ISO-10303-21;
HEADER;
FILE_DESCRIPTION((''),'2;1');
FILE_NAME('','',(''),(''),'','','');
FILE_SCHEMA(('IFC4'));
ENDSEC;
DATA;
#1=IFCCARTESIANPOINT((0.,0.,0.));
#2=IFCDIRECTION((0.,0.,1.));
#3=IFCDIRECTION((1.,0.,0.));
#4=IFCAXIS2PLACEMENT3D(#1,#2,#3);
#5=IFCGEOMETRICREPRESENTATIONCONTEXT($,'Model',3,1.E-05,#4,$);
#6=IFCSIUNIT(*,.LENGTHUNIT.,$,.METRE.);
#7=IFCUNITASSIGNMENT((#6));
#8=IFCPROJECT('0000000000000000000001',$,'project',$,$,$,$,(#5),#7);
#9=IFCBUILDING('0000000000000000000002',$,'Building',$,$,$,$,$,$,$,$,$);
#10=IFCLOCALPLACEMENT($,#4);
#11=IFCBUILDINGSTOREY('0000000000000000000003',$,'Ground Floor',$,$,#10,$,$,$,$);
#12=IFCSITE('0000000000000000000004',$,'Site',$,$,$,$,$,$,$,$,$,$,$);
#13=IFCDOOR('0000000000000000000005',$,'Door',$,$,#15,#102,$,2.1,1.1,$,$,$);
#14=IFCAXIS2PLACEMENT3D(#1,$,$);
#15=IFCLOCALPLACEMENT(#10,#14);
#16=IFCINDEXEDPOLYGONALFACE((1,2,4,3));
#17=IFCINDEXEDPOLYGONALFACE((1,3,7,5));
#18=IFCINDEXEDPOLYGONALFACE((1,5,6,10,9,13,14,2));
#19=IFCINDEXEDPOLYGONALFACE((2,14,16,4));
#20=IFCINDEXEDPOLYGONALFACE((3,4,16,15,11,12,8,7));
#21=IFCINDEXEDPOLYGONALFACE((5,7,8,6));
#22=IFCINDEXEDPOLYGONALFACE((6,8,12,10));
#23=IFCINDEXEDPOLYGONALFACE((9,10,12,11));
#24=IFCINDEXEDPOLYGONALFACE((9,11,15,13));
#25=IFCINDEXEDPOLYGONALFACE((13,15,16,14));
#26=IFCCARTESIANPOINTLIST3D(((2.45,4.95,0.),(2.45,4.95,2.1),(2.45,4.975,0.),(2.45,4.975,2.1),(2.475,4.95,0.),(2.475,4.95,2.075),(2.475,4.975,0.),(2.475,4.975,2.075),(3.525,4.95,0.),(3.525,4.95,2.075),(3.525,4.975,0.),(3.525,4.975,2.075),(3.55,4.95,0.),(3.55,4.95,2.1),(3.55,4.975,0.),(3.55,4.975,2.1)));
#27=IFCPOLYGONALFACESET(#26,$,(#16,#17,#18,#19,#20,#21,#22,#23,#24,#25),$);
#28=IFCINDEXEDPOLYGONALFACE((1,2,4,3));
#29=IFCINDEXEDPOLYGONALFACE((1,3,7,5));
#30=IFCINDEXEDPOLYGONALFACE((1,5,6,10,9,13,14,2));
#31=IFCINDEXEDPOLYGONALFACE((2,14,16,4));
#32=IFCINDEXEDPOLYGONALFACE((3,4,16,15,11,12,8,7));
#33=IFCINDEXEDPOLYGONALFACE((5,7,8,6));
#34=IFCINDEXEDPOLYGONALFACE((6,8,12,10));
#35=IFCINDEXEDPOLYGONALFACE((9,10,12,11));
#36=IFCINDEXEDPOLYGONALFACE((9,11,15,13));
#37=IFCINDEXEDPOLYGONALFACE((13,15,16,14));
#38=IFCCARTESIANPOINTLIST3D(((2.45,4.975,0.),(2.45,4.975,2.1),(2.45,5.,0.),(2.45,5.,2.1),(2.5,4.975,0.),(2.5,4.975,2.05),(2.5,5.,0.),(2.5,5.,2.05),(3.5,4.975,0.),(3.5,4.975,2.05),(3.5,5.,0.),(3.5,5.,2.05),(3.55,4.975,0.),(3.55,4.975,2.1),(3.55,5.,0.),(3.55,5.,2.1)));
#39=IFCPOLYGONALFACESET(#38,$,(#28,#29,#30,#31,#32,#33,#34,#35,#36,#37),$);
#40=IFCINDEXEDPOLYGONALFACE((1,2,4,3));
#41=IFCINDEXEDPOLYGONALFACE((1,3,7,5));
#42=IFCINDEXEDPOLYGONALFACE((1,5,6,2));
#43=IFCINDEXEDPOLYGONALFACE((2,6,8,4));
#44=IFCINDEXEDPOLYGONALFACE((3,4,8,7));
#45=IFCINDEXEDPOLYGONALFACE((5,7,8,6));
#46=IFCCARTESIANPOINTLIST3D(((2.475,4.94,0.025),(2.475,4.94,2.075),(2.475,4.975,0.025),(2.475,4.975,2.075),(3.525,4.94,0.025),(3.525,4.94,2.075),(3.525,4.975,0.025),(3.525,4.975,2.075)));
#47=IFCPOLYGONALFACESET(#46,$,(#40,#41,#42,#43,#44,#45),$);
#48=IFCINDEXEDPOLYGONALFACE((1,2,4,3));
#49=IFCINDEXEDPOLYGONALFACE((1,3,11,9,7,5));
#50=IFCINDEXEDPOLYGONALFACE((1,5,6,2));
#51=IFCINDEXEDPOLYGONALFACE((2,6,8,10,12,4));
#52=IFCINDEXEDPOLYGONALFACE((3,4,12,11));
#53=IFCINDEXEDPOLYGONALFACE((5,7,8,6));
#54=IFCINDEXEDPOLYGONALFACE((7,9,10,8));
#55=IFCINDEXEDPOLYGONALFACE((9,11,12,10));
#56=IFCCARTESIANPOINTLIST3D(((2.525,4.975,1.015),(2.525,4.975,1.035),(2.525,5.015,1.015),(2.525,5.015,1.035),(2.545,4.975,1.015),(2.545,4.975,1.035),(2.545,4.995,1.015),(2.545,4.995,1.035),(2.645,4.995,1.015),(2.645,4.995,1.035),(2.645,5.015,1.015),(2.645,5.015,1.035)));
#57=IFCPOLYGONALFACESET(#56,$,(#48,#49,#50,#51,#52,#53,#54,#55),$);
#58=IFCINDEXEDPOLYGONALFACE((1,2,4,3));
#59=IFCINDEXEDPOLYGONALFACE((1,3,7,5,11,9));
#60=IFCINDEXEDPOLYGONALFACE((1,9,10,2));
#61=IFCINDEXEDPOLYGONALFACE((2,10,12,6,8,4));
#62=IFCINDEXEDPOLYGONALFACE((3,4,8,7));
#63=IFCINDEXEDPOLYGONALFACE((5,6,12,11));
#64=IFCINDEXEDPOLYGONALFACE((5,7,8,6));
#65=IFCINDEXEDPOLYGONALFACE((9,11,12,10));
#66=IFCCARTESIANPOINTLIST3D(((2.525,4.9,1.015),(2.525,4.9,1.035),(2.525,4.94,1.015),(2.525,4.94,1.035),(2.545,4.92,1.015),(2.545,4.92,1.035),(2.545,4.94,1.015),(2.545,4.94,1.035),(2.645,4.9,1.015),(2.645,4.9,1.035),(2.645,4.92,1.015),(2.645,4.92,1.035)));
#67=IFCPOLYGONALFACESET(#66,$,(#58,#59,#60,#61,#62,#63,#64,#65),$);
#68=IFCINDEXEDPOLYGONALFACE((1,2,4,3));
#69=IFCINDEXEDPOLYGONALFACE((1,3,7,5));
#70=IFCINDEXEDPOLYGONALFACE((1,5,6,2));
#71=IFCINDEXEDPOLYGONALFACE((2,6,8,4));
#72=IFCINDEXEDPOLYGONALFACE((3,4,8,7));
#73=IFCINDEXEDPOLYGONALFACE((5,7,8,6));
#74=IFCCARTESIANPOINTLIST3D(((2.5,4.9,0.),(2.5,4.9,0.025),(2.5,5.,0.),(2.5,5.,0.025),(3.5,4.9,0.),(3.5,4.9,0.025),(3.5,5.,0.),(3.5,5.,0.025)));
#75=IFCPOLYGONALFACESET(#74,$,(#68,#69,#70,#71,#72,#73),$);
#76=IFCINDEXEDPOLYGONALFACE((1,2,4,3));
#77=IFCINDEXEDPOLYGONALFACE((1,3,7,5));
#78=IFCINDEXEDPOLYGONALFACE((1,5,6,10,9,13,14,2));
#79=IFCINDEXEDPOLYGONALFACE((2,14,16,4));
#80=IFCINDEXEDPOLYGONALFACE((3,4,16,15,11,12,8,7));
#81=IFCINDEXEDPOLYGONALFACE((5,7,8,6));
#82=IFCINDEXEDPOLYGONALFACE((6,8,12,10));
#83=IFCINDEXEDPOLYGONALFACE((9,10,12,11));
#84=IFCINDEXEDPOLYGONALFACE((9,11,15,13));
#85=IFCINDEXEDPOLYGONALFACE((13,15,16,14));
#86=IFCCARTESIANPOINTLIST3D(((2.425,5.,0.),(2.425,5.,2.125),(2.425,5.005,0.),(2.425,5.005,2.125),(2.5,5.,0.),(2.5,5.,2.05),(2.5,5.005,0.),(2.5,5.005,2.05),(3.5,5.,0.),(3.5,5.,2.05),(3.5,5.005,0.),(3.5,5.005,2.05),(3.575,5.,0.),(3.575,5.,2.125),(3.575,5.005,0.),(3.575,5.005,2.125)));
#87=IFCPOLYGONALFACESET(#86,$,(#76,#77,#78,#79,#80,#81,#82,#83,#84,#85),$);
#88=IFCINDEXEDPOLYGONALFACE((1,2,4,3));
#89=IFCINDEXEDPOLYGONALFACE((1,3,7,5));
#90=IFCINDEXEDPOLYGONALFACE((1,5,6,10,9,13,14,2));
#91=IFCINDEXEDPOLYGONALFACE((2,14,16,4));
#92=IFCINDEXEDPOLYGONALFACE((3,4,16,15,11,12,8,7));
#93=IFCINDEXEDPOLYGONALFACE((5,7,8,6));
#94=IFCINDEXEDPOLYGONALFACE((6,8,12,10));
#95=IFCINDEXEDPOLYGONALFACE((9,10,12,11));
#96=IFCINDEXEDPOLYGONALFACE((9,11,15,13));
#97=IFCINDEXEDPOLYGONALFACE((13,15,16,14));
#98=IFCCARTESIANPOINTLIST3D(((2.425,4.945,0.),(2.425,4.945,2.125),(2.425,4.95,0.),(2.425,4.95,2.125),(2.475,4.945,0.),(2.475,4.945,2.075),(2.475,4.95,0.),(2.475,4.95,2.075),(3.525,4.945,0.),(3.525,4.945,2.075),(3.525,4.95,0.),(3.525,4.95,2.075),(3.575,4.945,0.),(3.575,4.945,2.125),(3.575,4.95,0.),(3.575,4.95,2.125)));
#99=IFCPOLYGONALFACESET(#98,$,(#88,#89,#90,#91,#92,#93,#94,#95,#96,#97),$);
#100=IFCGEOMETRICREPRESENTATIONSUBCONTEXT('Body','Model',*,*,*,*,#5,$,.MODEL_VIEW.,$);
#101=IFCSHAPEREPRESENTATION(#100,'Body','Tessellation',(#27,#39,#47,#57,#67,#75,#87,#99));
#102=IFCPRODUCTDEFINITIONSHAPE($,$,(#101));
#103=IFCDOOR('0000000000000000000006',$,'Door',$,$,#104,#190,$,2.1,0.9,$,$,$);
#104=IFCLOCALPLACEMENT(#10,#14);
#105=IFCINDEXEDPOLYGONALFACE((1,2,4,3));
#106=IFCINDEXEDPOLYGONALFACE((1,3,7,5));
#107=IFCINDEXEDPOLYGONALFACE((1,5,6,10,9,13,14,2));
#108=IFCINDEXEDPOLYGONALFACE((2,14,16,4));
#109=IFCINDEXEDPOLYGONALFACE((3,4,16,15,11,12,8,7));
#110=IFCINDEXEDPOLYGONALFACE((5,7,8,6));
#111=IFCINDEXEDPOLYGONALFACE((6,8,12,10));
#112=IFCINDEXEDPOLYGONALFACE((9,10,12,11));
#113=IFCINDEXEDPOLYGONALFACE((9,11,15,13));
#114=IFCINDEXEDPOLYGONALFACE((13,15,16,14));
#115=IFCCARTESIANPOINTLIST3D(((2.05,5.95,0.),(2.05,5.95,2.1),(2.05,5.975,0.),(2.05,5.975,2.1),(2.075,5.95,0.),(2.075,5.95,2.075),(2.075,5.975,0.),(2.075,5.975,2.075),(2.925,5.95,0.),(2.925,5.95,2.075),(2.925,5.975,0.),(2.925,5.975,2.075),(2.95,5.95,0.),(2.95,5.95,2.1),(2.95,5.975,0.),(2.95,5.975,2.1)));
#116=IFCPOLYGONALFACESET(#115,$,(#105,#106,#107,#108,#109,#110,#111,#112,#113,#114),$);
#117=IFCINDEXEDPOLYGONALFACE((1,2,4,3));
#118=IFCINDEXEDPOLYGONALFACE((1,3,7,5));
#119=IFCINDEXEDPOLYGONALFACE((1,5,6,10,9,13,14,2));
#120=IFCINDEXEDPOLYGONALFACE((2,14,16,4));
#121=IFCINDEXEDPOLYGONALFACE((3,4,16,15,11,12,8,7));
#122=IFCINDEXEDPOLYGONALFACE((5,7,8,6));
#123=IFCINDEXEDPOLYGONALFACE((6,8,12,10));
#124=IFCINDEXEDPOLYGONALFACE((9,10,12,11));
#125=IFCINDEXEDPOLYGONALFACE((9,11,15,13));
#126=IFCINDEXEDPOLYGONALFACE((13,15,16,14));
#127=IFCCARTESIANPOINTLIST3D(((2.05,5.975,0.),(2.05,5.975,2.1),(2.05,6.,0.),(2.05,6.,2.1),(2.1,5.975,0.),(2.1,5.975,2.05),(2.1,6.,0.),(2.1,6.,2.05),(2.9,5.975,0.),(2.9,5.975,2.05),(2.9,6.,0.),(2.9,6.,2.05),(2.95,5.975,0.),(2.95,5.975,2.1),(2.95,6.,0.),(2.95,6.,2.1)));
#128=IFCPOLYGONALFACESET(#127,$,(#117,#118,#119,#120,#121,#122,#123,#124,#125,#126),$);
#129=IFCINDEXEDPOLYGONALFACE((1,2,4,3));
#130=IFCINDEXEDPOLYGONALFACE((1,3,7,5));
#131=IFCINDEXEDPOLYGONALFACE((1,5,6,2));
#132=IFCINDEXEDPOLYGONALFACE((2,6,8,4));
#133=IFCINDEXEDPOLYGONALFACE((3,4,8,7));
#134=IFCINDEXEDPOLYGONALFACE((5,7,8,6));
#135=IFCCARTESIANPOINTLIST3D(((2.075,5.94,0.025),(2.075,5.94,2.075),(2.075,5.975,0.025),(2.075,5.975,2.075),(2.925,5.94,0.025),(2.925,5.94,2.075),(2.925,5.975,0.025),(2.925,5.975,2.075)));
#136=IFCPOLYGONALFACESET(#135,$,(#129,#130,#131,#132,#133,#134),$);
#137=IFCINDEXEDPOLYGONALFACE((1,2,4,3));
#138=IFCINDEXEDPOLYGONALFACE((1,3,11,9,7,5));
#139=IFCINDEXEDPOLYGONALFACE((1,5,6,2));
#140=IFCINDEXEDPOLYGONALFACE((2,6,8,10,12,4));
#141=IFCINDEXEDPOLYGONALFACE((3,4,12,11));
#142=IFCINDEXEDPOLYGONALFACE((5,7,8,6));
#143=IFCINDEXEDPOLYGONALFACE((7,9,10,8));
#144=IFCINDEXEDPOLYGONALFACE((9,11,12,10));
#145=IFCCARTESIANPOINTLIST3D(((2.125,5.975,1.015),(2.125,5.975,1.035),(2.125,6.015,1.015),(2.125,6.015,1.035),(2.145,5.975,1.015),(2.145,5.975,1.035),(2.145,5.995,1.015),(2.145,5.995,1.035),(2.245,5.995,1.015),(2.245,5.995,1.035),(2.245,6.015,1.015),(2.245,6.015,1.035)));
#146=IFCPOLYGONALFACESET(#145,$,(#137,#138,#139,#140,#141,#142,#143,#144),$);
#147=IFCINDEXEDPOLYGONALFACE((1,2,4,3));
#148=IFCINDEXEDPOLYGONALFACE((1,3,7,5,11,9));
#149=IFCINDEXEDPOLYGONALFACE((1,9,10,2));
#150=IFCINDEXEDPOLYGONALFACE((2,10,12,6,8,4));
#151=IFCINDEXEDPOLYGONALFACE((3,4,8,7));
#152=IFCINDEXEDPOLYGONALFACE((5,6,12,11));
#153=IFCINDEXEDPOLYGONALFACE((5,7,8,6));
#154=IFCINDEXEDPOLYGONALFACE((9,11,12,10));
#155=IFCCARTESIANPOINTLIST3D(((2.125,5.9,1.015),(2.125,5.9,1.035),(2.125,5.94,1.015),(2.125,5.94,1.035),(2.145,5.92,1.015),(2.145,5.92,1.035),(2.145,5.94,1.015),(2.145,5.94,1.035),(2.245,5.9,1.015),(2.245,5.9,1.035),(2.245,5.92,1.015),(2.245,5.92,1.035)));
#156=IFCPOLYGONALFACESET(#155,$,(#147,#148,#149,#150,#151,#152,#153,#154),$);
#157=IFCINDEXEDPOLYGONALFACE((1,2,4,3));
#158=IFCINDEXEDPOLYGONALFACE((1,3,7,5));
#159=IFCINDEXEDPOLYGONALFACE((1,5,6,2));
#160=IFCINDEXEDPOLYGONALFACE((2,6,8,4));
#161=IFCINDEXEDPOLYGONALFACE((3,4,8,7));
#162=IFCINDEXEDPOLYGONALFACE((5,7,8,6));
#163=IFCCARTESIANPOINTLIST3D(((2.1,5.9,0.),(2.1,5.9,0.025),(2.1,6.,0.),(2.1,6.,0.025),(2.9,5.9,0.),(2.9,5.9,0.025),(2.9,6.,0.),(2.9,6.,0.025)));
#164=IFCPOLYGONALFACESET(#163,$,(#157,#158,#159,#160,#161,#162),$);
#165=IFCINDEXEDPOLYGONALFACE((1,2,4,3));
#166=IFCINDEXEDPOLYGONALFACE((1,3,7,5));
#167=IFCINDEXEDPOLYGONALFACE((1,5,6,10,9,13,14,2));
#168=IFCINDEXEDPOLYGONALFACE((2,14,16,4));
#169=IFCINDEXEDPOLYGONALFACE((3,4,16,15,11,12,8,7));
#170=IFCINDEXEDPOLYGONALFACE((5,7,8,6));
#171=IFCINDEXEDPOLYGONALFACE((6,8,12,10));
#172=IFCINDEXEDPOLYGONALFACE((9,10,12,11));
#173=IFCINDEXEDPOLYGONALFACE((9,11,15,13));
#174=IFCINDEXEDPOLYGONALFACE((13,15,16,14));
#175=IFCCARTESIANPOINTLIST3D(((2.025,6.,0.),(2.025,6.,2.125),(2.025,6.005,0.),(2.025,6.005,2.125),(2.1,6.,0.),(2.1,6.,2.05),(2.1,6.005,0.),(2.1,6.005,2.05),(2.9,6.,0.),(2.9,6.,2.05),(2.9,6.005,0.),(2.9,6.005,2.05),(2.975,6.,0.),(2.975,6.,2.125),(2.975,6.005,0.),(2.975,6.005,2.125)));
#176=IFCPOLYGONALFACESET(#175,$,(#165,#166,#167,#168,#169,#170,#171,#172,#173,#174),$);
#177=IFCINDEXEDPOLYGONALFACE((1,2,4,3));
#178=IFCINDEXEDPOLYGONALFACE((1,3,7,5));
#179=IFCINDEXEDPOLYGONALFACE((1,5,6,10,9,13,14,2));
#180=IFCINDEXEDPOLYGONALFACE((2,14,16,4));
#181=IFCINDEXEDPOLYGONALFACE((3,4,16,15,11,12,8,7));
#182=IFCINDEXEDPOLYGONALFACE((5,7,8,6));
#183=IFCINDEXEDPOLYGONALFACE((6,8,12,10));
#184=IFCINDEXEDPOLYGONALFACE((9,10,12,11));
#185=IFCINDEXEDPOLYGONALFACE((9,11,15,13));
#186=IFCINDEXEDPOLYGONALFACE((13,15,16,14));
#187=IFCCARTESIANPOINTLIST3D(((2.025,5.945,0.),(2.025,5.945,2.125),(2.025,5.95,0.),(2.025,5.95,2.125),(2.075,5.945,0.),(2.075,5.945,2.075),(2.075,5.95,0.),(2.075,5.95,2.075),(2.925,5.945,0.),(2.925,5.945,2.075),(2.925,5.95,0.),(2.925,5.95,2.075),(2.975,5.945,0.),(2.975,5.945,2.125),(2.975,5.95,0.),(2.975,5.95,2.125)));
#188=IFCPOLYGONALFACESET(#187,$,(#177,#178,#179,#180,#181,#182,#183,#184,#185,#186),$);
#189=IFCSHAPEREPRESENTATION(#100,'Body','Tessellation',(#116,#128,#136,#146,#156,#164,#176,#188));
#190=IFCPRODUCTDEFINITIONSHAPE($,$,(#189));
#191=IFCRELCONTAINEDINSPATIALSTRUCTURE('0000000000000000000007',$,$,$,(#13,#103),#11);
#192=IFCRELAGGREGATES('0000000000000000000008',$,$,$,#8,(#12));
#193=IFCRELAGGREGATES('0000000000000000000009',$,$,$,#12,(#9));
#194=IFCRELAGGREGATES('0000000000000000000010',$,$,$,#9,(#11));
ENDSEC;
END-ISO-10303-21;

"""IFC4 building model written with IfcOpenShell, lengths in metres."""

from ifc_helpers import new_model, si_unit, frame, origin_with_axes, place, context, subcontext, project, spatial, line, indexed_curve, outline, extrude, element, save


model = new_model("IFC4")

# Units and contexts
model_context = context("Model", 3, precision=1e-05, world=origin_with_axes())
body_context = subcontext(model_context, "Body", "Model", "MODEL_VIEW")
ifc_project = project(units=[si_unit("LENGTHUNIT", "METRE")], contexts=[model_context])

# Site, building, storey
site = spatial("IfcSite", under=ifc_project, Name="Site")
building = spatial("IfcBuilding", under=site, Name="Building")
storey_placement = place(None, origin_with_axes())
storey = spatial("IfcBuildingStorey", under=building, at=storey_placement, Name="Ground Floor")

# Doors
door_1_placement = place(storey_placement, frame((3.55, 5.0, 0.0), z_axis=(0.0, 0.0, 1.0), x_axis=(-1.0, 0.0, 0.0)))
element("IfcDoor", 1, at=door_1_placement, inside=storey, Name="Door", OverallHeight=2.1, OverallWidth=1.1, context=body_context, shape_type="SweptSolid", body=[
    extrude(outline(indexed_curve([(0.0, 0.0), (0.0, 2.1), (1.1, 2.1), (1.1, 0.0), (1.075, 0.0), (1.075, 2.075), (0.025, 2.075), (0.025, 0.0)], segments=[line(1, 2, 3, 4, 5, 6, 7, 8, 1)])), frame((0.0, 0.025, 0.0), z_axis=(0.0, -1.0, 0.0), x_axis=(1.0, 0.0, 0.0)), (0.0, 0.0, -1.0), 0.025),
    extrude(outline(indexed_curve([(0.0, 0.0), (0.0, 2.1), (1.1, 2.1), (1.1, 0.0), (1.05, 0.0), (1.05, 2.05), (0.05, 2.05), (0.05, 0.0)], segments=[line(1, 2, 3, 4, 5, 6, 7, 8, 1)])), frame((0.0, 0.0, 0.0), z_axis=(0.0, -1.0, 0.0), x_axis=(1.0, 0.0, 0.0)), (0.0, 0.0, -1.0), 0.025),
    extrude(outline(indexed_curve([(0.0, 0.0), (1.05, 0.0), (1.05, 0.035), (0.0, 0.035)], segments=[line(1, 2, 3, 4, 1)])), frame((0.025, 0.025, 0.025), z_axis=(0.0, 0.0, 1.0), x_axis=(1.0, 0.0, 0.0)), (0.0, 0.0, 1.0), 2.05),
    extrude(outline(indexed_curve([(0.0, 0.0), (0.0, -0.04), (-0.12, -0.04), (-0.12, -0.02), (-0.02, -0.02), (-0.02, 0.0)], segments=[line(1, 2, 3, 4, 5, 6, 1)])), frame((1.025, 0.025, 1.015), z_axis=(0.0, 0.0, 1.0), x_axis=(1.0, 0.0, 0.0)), (0.0, 0.0, 1.0), 0.02),
    extrude(outline(indexed_curve([(0.0, 0.0), (0.0, 0.04), (-0.12, 0.04), (-0.12, 0.02), (-0.02, 0.02), (-0.02, 0.0)], segments=[line(1, 2, 3, 4, 5, 6, 1)])), frame((1.025, 0.06, 1.015), z_axis=(0.0, 0.0, 1.0), x_axis=(1.0, 0.0, 0.0)), (0.0, 0.0, 1.0), 0.02),
    extrude(outline(indexed_curve([(0.0, 0.0), (1.0, 0.0), (1.0, 0.1), (0.0, 0.1)], segments=[line(1, 2, 3, 4, 1)])), frame((0.05, 0.0, 0.0), z_axis=(0.0, 0.0, 1.0), x_axis=(1.0, 0.0, 0.0)), (0.0, 0.0, 1.0), 0.025),
    extrude(outline(indexed_curve([(0.0, 0.0), (0.0, 2.125), (1.15, 2.125), (1.15, 0.0), (1.075, 0.0), (1.075, 2.05), (0.075, 2.05), (0.075, 0.0)], segments=[line(1, 2, 3, 4, 5, 6, 7, 8, 1)])), frame((-0.025, -0.005, 0.0), z_axis=(0.0, -1.0, 0.0), x_axis=(1.0, 0.0, 0.0)), (0.0, 0.0, -1.0), 0.005),
    extrude(outline(indexed_curve([(0.0, 0.0), (0.0, 2.125), (1.15, 2.125), (1.15, 0.0), (1.1, 0.0), (1.1, 2.075), (0.05, 2.075), (0.05, 0.0)], segments=[line(1, 2, 3, 4, 5, 6, 7, 8, 1)])), frame((-0.025, 0.05, 0.0), z_axis=(0.0, -1.0, 0.0), x_axis=(1.0, 0.0, 0.0)), (0.0, 0.0, -1.0), 0.005),
])
door_2_placement = place(storey_placement, frame((2.95, 6.0, 0.0), z_axis=(0.0, 0.0, 1.0), x_axis=(-1.0, 0.0, 0.0)))
element("IfcDoor", 2, at=door_2_placement, inside=storey, Name="Door", OverallHeight=2.1, OverallWidth=0.9, context=body_context, shape_type="SweptSolid", body=[
    extrude(outline(indexed_curve([(0.0, 0.0), (0.0, 2.1), (0.9, 2.1), (0.9, 0.0), (0.875, 0.0), (0.875, 2.075), (0.025, 2.075), (0.025, 0.0)], segments=[line(1, 2, 3, 4, 5, 6, 7, 8, 1)])), frame((0.0, 0.025, 0.0), z_axis=(0.0, -1.0, 0.0), x_axis=(1.0, 0.0, 0.0)), (0.0, 0.0, -1.0), 0.025),
    extrude(outline(indexed_curve([(0.0, 0.0), (0.0, 2.1), (0.9, 2.1), (0.9, 0.0), (0.85, 0.0), (0.85, 2.05), (0.05, 2.05), (0.05, 0.0)], segments=[line(1, 2, 3, 4, 5, 6, 7, 8, 1)])), frame((0.0, 0.0, 0.0), z_axis=(0.0, -1.0, 0.0), x_axis=(1.0, 0.0, 0.0)), (0.0, 0.0, -1.0), 0.025),
    extrude(outline(indexed_curve([(0.0, 0.0), (0.85, 0.0), (0.85, 0.035), (0.0, 0.035)], segments=[line(1, 2, 3, 4, 1)])), frame((0.025, 0.025, 0.025), z_axis=(0.0, 0.0, 1.0), x_axis=(1.0, 0.0, 0.0)), (0.0, 0.0, 1.0), 2.05),
    extrude(outline(indexed_curve([(0.0, 0.0), (0.0, -0.04), (-0.12, -0.04), (-0.12, -0.02), (-0.02, -0.02), (-0.02, 0.0)], segments=[line(1, 2, 3, 4, 5, 6, 1)])), frame((0.825, 0.025, 1.015), z_axis=(0.0, 0.0, 1.0), x_axis=(1.0, 0.0, 0.0)), (0.0, 0.0, 1.0), 0.02),
    extrude(outline(indexed_curve([(0.0, 0.0), (0.0, 0.04), (-0.12, 0.04), (-0.12, 0.02), (-0.02, 0.02), (-0.02, 0.0)], segments=[line(1, 2, 3, 4, 5, 6, 1)])), frame((0.825, 0.06, 1.015), z_axis=(0.0, 0.0, 1.0), x_axis=(1.0, 0.0, 0.0)), (0.0, 0.0, 1.0), 0.02),
    extrude(outline(indexed_curve([(0.0, 0.0), (0.8, 0.0), (0.8, 0.1), (0.0, 0.1)], segments=[line(1, 2, 3, 4, 1)])), frame((0.05, 0.0, 0.0), z_axis=(0.0, 0.0, 1.0), x_axis=(1.0, 0.0, 0.0)), (0.0, 0.0, 1.0), 0.025),
    extrude(outline(indexed_curve([(0.0, 0.0), (0.0, 2.125), (0.95, 2.125), (0.95, 0.0), (0.875, 0.0), (0.875, 2.05), (0.075, 2.05), (0.075, 0.0)], segments=[line(1, 2, 3, 4, 5, 6, 7, 8, 1)])), frame((-0.025, -0.005, 0.0), z_axis=(0.0, -1.0, 0.0), x_axis=(1.0, 0.0, 0.0)), (0.0, 0.0, -1.0), 0.005),
    extrude(outline(indexed_curve([(0.0, 0.0), (0.0, 2.125), (0.95, 2.125), (0.95, 0.0), (0.9, 0.0), (0.9, 2.075), (0.05, 2.075), (0.05, 0.0)], segments=[line(1, 2, 3, 4, 5, 6, 7, 8, 1)])), frame((-0.025, 0.05, 0.0), z_axis=(0.0, -1.0, 0.0), x_axis=(1.0, 0.0, 0.0)), (0.0, 0.0, -1.0), 0.005),
])

save(model, "model.ifc")
